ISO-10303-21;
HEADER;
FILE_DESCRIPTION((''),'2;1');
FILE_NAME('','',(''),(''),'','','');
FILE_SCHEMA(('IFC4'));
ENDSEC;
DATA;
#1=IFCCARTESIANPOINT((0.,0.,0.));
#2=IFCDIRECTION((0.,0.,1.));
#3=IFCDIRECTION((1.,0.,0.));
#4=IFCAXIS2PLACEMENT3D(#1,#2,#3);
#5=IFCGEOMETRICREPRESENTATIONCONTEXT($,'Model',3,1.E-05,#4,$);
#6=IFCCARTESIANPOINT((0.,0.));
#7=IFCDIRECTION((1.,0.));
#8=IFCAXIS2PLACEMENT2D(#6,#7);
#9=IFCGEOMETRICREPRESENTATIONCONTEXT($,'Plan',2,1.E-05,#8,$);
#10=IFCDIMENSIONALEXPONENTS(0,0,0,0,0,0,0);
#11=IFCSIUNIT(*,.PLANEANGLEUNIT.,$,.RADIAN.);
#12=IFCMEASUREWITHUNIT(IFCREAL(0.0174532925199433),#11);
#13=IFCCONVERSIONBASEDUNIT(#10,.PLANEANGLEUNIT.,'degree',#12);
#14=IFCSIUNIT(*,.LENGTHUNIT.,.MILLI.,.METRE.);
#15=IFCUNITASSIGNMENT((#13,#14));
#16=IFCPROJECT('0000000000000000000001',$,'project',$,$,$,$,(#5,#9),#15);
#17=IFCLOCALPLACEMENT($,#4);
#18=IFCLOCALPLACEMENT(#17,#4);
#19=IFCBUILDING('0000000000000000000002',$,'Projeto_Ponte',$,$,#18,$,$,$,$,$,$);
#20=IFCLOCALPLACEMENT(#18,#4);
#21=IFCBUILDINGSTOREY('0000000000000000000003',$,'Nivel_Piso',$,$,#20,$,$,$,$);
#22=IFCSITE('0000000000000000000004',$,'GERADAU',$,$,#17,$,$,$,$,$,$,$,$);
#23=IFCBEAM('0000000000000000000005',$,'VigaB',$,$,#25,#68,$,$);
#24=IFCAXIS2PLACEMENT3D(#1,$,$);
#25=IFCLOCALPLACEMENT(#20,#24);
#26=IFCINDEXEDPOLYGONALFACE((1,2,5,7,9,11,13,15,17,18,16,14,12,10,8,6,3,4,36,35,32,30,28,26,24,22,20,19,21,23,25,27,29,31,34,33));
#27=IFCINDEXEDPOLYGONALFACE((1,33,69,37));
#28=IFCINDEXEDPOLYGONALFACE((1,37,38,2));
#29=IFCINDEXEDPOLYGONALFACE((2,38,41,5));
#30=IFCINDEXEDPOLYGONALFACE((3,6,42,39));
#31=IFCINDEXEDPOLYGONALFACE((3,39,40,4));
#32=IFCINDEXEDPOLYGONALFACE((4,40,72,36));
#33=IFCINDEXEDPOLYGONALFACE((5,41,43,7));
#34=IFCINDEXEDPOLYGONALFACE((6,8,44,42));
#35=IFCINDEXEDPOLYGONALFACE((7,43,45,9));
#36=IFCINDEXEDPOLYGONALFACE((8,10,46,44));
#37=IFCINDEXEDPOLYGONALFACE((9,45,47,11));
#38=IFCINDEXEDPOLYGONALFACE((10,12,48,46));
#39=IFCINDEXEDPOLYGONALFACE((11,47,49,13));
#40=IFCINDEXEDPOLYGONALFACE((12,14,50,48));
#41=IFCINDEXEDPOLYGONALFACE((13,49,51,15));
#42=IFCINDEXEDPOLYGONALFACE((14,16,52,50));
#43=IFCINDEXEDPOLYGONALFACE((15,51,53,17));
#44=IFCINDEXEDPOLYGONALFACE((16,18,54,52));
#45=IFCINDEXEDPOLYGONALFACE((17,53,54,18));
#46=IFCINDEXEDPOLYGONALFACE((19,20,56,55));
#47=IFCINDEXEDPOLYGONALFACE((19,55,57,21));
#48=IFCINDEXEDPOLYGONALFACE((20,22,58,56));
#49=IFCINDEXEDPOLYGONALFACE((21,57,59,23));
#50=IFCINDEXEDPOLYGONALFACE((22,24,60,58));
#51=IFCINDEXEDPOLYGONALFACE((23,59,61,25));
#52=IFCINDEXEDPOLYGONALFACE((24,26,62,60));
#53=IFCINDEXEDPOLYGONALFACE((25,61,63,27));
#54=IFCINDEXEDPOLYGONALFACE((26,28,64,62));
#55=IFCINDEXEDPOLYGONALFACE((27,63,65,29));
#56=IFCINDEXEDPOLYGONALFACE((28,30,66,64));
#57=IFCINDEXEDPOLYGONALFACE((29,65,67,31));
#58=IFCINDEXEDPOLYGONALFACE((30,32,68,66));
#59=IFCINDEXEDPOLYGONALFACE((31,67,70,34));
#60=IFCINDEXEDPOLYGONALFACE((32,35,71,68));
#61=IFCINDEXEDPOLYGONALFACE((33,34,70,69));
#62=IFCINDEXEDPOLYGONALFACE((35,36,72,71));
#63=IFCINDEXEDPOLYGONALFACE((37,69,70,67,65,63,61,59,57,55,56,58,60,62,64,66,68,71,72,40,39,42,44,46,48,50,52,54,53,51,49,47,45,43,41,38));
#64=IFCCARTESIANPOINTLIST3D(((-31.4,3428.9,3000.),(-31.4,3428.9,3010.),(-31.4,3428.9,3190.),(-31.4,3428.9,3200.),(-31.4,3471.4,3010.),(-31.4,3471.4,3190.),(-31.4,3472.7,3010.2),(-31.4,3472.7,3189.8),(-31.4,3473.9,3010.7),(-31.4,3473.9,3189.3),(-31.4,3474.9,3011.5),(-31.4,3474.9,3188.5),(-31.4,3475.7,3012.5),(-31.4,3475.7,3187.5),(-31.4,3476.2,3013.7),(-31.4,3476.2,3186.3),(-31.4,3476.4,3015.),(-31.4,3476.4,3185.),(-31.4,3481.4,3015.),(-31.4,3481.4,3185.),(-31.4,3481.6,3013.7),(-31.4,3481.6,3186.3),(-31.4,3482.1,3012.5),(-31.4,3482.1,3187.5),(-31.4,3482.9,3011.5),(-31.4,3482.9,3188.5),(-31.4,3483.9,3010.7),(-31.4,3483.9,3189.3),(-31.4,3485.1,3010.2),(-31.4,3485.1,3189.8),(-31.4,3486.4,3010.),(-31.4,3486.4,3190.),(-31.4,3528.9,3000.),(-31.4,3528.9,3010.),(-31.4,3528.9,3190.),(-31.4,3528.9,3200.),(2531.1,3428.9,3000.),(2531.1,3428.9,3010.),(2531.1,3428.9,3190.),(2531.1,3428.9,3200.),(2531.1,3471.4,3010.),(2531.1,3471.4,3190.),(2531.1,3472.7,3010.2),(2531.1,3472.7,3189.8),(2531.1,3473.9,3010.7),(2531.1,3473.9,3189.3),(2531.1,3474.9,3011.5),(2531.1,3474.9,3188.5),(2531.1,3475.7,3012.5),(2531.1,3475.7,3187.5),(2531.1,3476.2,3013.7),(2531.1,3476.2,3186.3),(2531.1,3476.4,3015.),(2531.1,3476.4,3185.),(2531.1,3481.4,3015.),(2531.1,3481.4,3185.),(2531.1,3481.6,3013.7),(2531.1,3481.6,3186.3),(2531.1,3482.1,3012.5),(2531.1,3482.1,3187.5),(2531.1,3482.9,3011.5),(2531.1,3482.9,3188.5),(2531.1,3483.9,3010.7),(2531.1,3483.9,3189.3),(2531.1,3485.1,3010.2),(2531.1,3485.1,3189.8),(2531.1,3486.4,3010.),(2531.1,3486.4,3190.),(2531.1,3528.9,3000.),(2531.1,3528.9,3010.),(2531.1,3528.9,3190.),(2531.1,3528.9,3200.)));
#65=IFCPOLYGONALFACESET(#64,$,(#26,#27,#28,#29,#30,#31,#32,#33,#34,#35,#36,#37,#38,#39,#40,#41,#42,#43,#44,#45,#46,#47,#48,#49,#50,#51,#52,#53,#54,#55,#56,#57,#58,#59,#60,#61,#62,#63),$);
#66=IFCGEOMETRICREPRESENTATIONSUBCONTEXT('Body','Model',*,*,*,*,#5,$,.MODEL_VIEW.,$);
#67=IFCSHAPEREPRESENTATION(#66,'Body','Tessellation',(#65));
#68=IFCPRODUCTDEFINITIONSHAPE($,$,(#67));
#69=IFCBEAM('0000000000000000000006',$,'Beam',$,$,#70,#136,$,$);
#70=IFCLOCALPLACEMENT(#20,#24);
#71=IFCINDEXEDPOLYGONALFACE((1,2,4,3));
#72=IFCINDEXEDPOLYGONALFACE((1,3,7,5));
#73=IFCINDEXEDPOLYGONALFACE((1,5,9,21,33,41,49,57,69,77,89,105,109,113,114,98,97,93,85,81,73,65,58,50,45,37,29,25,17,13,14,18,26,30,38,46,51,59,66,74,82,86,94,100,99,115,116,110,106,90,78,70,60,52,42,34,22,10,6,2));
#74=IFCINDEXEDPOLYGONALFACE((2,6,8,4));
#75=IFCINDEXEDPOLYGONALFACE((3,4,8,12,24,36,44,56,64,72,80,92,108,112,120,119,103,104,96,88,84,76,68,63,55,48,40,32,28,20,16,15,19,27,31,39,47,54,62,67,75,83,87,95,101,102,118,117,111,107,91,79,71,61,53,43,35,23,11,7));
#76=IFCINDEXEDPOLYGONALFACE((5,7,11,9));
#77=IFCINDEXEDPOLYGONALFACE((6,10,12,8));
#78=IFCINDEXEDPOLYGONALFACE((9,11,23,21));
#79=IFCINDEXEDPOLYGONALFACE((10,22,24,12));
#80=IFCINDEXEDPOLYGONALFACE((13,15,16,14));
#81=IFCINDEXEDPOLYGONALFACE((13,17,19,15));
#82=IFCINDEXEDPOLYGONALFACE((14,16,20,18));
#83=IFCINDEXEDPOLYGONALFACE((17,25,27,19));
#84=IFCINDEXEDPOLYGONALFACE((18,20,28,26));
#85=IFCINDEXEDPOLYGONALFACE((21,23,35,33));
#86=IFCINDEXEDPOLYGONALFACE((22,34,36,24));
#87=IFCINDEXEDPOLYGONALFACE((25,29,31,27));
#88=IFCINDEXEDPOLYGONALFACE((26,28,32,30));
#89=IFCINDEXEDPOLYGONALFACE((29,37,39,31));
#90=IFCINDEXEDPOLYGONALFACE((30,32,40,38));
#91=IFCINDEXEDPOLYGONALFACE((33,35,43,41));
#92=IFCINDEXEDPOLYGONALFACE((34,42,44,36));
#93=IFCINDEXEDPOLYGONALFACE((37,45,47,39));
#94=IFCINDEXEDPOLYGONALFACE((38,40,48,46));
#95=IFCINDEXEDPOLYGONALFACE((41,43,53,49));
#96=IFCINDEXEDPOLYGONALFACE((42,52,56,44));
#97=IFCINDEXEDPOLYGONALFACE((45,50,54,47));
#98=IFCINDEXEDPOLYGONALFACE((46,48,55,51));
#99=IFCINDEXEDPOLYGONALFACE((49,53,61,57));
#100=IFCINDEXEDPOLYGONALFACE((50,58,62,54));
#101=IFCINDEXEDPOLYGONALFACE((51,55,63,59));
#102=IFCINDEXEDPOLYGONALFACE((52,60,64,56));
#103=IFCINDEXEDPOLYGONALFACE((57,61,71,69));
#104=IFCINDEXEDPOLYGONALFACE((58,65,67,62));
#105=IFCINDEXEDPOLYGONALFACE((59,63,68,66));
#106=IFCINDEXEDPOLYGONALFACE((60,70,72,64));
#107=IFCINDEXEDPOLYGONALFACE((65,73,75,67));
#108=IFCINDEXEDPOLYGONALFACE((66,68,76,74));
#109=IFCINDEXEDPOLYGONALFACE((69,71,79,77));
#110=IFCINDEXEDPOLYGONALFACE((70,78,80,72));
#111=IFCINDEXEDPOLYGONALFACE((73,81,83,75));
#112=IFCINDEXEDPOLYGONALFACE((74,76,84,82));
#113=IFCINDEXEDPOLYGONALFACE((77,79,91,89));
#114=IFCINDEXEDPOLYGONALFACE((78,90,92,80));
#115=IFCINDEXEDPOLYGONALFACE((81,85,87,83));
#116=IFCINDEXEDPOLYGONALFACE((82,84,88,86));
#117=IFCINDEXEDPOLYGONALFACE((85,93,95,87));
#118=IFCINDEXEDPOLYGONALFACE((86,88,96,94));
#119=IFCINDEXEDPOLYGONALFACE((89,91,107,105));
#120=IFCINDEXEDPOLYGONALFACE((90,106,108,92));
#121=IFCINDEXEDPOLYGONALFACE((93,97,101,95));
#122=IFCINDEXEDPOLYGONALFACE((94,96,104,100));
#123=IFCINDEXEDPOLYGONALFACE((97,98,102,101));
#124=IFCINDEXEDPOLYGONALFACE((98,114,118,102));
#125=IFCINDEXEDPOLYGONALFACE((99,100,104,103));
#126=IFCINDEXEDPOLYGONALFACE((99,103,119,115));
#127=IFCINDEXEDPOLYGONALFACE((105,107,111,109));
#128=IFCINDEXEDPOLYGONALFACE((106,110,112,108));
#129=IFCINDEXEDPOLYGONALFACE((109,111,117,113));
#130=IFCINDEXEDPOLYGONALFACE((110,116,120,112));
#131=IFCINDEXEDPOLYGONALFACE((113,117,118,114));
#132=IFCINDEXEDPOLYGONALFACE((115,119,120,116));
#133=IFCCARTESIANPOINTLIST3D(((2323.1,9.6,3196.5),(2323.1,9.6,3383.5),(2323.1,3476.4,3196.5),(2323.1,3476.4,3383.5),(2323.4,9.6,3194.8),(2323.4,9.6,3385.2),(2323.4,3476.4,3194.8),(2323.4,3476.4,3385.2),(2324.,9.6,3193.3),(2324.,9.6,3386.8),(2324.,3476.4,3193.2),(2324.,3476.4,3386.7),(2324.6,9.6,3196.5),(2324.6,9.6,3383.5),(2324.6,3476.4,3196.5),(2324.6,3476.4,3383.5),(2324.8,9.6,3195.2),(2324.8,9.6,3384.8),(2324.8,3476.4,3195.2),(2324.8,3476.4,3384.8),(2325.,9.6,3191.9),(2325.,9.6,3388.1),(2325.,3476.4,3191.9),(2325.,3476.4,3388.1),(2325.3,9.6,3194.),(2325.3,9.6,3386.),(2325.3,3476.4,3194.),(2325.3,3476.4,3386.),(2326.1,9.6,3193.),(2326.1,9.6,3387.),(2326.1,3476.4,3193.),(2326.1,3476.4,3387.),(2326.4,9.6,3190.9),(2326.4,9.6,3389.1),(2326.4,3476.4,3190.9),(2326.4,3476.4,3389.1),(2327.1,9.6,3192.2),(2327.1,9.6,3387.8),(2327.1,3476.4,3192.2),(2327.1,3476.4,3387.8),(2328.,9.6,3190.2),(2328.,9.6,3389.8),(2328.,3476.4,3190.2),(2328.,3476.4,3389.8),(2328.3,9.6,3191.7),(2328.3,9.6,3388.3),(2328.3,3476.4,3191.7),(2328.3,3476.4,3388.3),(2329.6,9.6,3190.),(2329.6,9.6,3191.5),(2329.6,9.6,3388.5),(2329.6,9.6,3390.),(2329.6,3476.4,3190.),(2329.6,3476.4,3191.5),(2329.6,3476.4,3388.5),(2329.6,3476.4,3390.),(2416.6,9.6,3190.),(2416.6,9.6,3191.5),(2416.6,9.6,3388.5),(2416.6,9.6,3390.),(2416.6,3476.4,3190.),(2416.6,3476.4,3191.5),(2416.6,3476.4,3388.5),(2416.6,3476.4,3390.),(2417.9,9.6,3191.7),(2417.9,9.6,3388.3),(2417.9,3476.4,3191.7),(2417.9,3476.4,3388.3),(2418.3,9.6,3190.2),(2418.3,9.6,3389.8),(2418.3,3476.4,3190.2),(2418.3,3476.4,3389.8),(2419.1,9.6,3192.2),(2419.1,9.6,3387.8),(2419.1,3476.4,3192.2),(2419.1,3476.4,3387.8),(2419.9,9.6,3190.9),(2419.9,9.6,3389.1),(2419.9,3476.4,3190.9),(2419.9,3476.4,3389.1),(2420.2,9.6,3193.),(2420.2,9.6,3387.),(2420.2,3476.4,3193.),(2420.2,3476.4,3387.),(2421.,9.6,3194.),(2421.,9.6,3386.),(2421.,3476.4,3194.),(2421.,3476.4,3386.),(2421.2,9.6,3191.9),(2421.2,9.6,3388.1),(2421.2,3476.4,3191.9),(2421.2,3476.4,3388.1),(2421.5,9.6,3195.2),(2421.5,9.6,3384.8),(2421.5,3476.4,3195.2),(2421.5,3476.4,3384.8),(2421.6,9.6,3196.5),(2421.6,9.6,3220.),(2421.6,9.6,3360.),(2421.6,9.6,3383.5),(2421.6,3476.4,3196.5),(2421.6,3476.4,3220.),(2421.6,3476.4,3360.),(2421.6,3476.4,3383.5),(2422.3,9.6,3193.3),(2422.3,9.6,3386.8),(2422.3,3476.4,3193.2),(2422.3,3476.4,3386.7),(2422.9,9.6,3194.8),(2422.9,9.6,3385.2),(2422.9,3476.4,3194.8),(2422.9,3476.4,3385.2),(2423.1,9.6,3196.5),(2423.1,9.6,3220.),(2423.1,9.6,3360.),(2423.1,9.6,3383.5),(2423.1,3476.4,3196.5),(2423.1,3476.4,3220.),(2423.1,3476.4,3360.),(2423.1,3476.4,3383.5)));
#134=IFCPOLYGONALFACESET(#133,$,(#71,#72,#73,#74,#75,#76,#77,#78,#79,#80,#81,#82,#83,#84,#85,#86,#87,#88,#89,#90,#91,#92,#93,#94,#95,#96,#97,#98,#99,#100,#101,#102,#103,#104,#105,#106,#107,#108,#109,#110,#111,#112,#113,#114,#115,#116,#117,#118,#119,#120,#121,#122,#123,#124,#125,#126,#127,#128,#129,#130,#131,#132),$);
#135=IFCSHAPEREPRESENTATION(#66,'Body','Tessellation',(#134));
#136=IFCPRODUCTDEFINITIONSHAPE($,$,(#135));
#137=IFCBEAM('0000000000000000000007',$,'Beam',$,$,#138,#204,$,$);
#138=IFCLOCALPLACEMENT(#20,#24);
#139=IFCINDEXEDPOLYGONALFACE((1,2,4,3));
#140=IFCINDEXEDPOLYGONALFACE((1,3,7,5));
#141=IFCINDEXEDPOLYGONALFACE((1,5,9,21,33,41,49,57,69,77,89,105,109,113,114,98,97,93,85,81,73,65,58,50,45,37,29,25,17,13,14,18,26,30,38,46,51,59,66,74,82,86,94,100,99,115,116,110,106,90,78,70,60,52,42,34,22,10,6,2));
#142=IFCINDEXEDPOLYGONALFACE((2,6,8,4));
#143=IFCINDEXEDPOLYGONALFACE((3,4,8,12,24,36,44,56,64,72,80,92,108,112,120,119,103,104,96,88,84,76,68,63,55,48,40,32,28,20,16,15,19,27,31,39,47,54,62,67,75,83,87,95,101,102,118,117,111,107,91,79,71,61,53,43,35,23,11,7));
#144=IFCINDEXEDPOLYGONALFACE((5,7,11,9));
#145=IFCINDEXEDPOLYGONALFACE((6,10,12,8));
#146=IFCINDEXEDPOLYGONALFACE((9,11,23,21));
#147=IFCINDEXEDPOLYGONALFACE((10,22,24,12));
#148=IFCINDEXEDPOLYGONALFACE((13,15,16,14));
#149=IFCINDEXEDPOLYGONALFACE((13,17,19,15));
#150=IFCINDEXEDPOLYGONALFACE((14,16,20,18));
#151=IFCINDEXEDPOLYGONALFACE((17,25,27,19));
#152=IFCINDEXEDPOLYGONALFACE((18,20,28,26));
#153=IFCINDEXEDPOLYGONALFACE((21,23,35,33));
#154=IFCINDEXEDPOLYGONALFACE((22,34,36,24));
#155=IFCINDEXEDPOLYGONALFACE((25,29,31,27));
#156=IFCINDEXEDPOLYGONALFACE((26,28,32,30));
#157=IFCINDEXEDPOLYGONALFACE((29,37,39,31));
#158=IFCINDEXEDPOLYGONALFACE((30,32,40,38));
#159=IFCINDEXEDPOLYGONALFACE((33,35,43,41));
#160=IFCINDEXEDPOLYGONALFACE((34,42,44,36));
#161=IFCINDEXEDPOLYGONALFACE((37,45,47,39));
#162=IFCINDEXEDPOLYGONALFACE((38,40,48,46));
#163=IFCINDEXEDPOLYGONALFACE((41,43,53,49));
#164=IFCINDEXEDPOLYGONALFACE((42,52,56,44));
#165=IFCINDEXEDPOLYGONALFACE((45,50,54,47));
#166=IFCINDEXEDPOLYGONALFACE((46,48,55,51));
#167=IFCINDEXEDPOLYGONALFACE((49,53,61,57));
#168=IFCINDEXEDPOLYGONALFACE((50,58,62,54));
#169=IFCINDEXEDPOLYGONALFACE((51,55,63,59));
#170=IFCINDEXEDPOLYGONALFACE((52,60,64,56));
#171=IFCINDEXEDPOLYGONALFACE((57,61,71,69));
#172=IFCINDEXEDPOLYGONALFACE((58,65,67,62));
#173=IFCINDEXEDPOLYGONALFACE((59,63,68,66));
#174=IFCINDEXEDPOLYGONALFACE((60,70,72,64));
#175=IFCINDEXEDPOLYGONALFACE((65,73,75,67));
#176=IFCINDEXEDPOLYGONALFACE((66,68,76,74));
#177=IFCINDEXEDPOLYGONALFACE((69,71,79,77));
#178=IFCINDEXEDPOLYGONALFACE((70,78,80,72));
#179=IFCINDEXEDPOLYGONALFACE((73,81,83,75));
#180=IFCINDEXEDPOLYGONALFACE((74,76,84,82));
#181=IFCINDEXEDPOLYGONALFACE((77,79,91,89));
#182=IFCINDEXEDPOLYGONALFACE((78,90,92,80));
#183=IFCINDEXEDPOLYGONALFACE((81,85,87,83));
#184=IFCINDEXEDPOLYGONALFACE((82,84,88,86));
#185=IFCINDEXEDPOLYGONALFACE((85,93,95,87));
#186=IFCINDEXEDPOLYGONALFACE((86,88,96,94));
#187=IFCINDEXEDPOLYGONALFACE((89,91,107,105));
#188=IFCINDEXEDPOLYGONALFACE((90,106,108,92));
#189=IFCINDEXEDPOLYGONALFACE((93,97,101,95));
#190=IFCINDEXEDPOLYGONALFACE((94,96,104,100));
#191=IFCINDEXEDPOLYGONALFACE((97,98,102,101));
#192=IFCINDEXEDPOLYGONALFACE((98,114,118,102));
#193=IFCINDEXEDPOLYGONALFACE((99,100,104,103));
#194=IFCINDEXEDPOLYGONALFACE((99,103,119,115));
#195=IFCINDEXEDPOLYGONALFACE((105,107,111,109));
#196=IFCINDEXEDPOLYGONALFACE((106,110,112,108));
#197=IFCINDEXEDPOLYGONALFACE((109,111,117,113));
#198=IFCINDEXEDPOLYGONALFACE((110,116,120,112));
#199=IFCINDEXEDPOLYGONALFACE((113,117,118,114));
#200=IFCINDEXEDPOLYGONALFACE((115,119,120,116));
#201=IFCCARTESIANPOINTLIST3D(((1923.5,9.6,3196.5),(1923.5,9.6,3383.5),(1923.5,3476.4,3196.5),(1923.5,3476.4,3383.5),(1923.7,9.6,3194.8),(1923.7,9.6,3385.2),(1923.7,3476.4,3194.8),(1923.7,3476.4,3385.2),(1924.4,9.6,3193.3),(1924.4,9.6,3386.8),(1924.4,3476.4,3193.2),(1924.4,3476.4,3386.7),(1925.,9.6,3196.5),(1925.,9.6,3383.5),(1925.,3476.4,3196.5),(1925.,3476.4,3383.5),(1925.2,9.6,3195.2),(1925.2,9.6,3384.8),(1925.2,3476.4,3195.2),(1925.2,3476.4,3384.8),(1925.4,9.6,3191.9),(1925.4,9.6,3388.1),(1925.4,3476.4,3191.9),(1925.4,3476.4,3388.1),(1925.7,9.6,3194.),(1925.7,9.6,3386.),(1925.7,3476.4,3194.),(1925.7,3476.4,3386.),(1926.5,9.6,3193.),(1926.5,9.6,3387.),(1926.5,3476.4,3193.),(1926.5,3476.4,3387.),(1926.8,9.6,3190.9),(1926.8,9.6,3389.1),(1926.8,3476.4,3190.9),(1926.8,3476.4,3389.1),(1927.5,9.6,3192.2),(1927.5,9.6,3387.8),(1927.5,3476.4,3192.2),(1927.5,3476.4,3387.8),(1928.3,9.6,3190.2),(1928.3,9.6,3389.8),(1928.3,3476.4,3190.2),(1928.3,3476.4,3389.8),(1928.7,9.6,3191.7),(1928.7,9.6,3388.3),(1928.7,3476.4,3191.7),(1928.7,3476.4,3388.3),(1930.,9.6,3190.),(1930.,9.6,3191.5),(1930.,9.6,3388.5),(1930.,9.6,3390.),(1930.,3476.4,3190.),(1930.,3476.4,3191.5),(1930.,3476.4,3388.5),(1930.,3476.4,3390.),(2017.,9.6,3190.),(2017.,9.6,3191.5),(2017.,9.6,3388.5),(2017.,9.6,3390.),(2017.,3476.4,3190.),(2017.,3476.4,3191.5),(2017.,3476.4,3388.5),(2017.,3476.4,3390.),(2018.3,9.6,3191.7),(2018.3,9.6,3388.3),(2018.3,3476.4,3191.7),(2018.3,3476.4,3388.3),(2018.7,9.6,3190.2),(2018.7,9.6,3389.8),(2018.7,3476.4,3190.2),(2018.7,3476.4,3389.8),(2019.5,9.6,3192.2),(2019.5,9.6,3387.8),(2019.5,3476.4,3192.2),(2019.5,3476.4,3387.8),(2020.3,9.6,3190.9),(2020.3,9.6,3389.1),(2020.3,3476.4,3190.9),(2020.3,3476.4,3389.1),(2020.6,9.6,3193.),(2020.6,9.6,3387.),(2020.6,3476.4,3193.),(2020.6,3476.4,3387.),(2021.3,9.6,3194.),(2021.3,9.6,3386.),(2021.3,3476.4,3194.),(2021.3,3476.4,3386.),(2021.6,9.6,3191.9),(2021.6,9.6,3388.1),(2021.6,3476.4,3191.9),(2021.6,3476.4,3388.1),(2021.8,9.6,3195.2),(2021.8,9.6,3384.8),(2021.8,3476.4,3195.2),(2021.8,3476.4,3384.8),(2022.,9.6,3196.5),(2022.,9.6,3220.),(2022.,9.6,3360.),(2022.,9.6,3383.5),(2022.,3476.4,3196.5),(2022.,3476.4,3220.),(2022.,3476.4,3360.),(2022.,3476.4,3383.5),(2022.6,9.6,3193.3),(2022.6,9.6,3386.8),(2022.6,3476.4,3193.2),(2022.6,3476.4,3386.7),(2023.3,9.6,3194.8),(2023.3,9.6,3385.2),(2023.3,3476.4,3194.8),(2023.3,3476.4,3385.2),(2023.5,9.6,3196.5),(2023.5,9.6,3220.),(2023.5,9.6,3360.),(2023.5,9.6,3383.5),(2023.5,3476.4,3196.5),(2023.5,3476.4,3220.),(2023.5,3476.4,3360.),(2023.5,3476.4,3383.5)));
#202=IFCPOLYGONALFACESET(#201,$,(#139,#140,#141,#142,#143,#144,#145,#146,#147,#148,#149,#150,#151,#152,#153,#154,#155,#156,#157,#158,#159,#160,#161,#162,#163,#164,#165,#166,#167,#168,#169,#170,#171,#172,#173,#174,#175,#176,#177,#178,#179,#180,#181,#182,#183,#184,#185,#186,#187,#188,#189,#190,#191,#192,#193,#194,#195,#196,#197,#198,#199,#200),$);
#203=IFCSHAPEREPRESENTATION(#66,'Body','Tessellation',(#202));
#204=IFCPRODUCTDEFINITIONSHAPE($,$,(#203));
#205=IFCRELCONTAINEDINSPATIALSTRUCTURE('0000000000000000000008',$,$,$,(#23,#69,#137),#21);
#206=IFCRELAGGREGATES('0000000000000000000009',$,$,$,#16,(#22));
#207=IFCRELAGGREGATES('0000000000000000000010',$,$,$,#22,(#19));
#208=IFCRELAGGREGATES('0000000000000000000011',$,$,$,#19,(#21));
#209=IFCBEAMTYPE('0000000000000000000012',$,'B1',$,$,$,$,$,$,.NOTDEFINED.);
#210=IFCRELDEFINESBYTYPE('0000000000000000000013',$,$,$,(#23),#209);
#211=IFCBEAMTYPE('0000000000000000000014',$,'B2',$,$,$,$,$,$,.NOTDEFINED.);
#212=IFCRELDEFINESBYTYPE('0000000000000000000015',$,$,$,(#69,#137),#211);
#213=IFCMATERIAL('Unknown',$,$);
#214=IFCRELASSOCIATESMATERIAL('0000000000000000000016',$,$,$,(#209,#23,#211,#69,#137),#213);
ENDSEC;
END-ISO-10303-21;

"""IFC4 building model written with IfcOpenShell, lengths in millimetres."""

from ifc_helpers import new_model, entity, si_unit, converted_unit, frame, origin_with_axes, origin_2d_with_axis, place, context, subcontext, project, spatial, i_section, c_section, extrude, material, material_profile, profile_set, profile_usage, type_object, element, save


model = new_model("IFC4")

# Units and contexts
model_context = context("Model", 3, precision=1e-05, world=origin_with_axes())
plan_context = context("Plan", 2, precision=1e-05, world=origin_2d_with_axis())
body_context = subcontext(model_context, "Body", "Model", "MODEL_VIEW")
ifc_project = project(units=[converted_unit("PLANEANGLEUNIT", "degree", entity("IfcReal", 0.0174532925199433), si_unit("PLANEANGLEUNIT", "RADIAN"), dimensions=[0, 0, 0, 0, 0, 0, 0]), si_unit("LENGTHUNIT", "METRE", prefix="MILLI")], contexts=[model_context, plan_context])

# Site, building, storey
site_placement = place(None, origin_with_axes())
site = spatial("IfcSite", under=ifc_project, at=site_placement, Name="GERADAU")
building_placement = place(site_placement, origin_with_axes())
building = spatial("IfcBuilding", under=site, at=building_placement, Name="Projeto_Ponte")
storey_placement = place(building_placement, origin_with_axes())
storey = spatial("IfcBuildingStorey", under=building, at=storey_placement, Name="Nivel_Piso")

# Shared definitions
ifc_material = material(Name="Unknown")

# Beams
ifc_material_profile_1 = material_profile(ifc_material, i_section(OverallWidth=100.0, OverallDepth=200.0, WebThickness=5.0, FlangeThickness=10.0, FilletRadius=5.0))
ifc_profile_set_1 = profile_set([ifc_material_profile_1])
beam_type_1 = type_object("IfcBeamType", Name="B1", PredefinedType="NOTDEFINED", material=ifc_profile_set_1)
ifc_profile_usage_1 = profile_usage(ifc_profile_set_1, cardinal=5)
beam_1_placement = place(storey_placement, frame((-31.4, 3478.9, 3100.0), z_axis=(1.0, 0.0, 0.0), x_axis=(0.0, 1.0, 0.0)))
element("IfcBeam", 1, at=beam_1_placement, inside=storey, type_object=beam_type_1, material=ifc_profile_usage_1, Name="VigaB", context=body_context, shape_type="SweptSolid", body=[
    extrude(i_section(OverallWidth=100.0, OverallDepth=200.0, WebThickness=5.0, FlangeThickness=10.0, FilletRadius=5.0), origin_with_axes(), (0.0, 0.0, 1.0), 2562.5),
])
ifc_material_profile_2 = material_profile(ifc_material, c_section(Depth=200.0, Width=100.0, WallThickness=1.5, Girth=30.0, InternalFilletRadius=5.0))
ifc_profile_set_2 = profile_set([ifc_material_profile_2])
ifc_profile_usage_2 = profile_usage(ifc_profile_set_2, cardinal=5)
beam_type_2 = type_object("IfcBeamType", Name="B2", PredefinedType="NOTDEFINED", material=ifc_profile_set_2)
beam_2_placement = place(storey_placement, frame((2373.1, 3476.4, 3290.0), z_axis=(0.0, -1.0, 0.0), x_axis=(1.0, 0.0, 0.0)))
element("IfcBeam", 2, at=beam_2_placement, inside=storey, type_object=beam_type_2, material=ifc_profile_usage_2, Name="Beam", context=body_context, shape_type="SweptSolid", body=[
    extrude(c_section(Depth=200.0, Width=100.0, WallThickness=1.5, Girth=30.0, InternalFilletRadius=5.0), origin_with_axes(), (0.0, 0.0, 1.0), 3466.8),
])
ifc_profile_usage_3 = profile_usage(ifc_profile_set_2, cardinal=5)
beam_3_placement = place(storey_placement, frame((1973.5, 3476.4, 3290.0), z_axis=(0.0, -1.0, 0.0), x_axis=(1.0, 0.0, 0.0)))
element("IfcBeam", 3, at=beam_3_placement, inside=storey, type_object=beam_type_2, material=ifc_profile_usage_3, Name="Beam", context=body_context, shape_type="SweptSolid", body=[
    extrude(c_section(Depth=200.0, Width=100.0, WallThickness=1.5, Girth=30.0, InternalFilletRadius=5.0), origin_with_axes(), (0.0, 0.0, 1.0), 3466.8),
])

save(model, "model.ifc")
